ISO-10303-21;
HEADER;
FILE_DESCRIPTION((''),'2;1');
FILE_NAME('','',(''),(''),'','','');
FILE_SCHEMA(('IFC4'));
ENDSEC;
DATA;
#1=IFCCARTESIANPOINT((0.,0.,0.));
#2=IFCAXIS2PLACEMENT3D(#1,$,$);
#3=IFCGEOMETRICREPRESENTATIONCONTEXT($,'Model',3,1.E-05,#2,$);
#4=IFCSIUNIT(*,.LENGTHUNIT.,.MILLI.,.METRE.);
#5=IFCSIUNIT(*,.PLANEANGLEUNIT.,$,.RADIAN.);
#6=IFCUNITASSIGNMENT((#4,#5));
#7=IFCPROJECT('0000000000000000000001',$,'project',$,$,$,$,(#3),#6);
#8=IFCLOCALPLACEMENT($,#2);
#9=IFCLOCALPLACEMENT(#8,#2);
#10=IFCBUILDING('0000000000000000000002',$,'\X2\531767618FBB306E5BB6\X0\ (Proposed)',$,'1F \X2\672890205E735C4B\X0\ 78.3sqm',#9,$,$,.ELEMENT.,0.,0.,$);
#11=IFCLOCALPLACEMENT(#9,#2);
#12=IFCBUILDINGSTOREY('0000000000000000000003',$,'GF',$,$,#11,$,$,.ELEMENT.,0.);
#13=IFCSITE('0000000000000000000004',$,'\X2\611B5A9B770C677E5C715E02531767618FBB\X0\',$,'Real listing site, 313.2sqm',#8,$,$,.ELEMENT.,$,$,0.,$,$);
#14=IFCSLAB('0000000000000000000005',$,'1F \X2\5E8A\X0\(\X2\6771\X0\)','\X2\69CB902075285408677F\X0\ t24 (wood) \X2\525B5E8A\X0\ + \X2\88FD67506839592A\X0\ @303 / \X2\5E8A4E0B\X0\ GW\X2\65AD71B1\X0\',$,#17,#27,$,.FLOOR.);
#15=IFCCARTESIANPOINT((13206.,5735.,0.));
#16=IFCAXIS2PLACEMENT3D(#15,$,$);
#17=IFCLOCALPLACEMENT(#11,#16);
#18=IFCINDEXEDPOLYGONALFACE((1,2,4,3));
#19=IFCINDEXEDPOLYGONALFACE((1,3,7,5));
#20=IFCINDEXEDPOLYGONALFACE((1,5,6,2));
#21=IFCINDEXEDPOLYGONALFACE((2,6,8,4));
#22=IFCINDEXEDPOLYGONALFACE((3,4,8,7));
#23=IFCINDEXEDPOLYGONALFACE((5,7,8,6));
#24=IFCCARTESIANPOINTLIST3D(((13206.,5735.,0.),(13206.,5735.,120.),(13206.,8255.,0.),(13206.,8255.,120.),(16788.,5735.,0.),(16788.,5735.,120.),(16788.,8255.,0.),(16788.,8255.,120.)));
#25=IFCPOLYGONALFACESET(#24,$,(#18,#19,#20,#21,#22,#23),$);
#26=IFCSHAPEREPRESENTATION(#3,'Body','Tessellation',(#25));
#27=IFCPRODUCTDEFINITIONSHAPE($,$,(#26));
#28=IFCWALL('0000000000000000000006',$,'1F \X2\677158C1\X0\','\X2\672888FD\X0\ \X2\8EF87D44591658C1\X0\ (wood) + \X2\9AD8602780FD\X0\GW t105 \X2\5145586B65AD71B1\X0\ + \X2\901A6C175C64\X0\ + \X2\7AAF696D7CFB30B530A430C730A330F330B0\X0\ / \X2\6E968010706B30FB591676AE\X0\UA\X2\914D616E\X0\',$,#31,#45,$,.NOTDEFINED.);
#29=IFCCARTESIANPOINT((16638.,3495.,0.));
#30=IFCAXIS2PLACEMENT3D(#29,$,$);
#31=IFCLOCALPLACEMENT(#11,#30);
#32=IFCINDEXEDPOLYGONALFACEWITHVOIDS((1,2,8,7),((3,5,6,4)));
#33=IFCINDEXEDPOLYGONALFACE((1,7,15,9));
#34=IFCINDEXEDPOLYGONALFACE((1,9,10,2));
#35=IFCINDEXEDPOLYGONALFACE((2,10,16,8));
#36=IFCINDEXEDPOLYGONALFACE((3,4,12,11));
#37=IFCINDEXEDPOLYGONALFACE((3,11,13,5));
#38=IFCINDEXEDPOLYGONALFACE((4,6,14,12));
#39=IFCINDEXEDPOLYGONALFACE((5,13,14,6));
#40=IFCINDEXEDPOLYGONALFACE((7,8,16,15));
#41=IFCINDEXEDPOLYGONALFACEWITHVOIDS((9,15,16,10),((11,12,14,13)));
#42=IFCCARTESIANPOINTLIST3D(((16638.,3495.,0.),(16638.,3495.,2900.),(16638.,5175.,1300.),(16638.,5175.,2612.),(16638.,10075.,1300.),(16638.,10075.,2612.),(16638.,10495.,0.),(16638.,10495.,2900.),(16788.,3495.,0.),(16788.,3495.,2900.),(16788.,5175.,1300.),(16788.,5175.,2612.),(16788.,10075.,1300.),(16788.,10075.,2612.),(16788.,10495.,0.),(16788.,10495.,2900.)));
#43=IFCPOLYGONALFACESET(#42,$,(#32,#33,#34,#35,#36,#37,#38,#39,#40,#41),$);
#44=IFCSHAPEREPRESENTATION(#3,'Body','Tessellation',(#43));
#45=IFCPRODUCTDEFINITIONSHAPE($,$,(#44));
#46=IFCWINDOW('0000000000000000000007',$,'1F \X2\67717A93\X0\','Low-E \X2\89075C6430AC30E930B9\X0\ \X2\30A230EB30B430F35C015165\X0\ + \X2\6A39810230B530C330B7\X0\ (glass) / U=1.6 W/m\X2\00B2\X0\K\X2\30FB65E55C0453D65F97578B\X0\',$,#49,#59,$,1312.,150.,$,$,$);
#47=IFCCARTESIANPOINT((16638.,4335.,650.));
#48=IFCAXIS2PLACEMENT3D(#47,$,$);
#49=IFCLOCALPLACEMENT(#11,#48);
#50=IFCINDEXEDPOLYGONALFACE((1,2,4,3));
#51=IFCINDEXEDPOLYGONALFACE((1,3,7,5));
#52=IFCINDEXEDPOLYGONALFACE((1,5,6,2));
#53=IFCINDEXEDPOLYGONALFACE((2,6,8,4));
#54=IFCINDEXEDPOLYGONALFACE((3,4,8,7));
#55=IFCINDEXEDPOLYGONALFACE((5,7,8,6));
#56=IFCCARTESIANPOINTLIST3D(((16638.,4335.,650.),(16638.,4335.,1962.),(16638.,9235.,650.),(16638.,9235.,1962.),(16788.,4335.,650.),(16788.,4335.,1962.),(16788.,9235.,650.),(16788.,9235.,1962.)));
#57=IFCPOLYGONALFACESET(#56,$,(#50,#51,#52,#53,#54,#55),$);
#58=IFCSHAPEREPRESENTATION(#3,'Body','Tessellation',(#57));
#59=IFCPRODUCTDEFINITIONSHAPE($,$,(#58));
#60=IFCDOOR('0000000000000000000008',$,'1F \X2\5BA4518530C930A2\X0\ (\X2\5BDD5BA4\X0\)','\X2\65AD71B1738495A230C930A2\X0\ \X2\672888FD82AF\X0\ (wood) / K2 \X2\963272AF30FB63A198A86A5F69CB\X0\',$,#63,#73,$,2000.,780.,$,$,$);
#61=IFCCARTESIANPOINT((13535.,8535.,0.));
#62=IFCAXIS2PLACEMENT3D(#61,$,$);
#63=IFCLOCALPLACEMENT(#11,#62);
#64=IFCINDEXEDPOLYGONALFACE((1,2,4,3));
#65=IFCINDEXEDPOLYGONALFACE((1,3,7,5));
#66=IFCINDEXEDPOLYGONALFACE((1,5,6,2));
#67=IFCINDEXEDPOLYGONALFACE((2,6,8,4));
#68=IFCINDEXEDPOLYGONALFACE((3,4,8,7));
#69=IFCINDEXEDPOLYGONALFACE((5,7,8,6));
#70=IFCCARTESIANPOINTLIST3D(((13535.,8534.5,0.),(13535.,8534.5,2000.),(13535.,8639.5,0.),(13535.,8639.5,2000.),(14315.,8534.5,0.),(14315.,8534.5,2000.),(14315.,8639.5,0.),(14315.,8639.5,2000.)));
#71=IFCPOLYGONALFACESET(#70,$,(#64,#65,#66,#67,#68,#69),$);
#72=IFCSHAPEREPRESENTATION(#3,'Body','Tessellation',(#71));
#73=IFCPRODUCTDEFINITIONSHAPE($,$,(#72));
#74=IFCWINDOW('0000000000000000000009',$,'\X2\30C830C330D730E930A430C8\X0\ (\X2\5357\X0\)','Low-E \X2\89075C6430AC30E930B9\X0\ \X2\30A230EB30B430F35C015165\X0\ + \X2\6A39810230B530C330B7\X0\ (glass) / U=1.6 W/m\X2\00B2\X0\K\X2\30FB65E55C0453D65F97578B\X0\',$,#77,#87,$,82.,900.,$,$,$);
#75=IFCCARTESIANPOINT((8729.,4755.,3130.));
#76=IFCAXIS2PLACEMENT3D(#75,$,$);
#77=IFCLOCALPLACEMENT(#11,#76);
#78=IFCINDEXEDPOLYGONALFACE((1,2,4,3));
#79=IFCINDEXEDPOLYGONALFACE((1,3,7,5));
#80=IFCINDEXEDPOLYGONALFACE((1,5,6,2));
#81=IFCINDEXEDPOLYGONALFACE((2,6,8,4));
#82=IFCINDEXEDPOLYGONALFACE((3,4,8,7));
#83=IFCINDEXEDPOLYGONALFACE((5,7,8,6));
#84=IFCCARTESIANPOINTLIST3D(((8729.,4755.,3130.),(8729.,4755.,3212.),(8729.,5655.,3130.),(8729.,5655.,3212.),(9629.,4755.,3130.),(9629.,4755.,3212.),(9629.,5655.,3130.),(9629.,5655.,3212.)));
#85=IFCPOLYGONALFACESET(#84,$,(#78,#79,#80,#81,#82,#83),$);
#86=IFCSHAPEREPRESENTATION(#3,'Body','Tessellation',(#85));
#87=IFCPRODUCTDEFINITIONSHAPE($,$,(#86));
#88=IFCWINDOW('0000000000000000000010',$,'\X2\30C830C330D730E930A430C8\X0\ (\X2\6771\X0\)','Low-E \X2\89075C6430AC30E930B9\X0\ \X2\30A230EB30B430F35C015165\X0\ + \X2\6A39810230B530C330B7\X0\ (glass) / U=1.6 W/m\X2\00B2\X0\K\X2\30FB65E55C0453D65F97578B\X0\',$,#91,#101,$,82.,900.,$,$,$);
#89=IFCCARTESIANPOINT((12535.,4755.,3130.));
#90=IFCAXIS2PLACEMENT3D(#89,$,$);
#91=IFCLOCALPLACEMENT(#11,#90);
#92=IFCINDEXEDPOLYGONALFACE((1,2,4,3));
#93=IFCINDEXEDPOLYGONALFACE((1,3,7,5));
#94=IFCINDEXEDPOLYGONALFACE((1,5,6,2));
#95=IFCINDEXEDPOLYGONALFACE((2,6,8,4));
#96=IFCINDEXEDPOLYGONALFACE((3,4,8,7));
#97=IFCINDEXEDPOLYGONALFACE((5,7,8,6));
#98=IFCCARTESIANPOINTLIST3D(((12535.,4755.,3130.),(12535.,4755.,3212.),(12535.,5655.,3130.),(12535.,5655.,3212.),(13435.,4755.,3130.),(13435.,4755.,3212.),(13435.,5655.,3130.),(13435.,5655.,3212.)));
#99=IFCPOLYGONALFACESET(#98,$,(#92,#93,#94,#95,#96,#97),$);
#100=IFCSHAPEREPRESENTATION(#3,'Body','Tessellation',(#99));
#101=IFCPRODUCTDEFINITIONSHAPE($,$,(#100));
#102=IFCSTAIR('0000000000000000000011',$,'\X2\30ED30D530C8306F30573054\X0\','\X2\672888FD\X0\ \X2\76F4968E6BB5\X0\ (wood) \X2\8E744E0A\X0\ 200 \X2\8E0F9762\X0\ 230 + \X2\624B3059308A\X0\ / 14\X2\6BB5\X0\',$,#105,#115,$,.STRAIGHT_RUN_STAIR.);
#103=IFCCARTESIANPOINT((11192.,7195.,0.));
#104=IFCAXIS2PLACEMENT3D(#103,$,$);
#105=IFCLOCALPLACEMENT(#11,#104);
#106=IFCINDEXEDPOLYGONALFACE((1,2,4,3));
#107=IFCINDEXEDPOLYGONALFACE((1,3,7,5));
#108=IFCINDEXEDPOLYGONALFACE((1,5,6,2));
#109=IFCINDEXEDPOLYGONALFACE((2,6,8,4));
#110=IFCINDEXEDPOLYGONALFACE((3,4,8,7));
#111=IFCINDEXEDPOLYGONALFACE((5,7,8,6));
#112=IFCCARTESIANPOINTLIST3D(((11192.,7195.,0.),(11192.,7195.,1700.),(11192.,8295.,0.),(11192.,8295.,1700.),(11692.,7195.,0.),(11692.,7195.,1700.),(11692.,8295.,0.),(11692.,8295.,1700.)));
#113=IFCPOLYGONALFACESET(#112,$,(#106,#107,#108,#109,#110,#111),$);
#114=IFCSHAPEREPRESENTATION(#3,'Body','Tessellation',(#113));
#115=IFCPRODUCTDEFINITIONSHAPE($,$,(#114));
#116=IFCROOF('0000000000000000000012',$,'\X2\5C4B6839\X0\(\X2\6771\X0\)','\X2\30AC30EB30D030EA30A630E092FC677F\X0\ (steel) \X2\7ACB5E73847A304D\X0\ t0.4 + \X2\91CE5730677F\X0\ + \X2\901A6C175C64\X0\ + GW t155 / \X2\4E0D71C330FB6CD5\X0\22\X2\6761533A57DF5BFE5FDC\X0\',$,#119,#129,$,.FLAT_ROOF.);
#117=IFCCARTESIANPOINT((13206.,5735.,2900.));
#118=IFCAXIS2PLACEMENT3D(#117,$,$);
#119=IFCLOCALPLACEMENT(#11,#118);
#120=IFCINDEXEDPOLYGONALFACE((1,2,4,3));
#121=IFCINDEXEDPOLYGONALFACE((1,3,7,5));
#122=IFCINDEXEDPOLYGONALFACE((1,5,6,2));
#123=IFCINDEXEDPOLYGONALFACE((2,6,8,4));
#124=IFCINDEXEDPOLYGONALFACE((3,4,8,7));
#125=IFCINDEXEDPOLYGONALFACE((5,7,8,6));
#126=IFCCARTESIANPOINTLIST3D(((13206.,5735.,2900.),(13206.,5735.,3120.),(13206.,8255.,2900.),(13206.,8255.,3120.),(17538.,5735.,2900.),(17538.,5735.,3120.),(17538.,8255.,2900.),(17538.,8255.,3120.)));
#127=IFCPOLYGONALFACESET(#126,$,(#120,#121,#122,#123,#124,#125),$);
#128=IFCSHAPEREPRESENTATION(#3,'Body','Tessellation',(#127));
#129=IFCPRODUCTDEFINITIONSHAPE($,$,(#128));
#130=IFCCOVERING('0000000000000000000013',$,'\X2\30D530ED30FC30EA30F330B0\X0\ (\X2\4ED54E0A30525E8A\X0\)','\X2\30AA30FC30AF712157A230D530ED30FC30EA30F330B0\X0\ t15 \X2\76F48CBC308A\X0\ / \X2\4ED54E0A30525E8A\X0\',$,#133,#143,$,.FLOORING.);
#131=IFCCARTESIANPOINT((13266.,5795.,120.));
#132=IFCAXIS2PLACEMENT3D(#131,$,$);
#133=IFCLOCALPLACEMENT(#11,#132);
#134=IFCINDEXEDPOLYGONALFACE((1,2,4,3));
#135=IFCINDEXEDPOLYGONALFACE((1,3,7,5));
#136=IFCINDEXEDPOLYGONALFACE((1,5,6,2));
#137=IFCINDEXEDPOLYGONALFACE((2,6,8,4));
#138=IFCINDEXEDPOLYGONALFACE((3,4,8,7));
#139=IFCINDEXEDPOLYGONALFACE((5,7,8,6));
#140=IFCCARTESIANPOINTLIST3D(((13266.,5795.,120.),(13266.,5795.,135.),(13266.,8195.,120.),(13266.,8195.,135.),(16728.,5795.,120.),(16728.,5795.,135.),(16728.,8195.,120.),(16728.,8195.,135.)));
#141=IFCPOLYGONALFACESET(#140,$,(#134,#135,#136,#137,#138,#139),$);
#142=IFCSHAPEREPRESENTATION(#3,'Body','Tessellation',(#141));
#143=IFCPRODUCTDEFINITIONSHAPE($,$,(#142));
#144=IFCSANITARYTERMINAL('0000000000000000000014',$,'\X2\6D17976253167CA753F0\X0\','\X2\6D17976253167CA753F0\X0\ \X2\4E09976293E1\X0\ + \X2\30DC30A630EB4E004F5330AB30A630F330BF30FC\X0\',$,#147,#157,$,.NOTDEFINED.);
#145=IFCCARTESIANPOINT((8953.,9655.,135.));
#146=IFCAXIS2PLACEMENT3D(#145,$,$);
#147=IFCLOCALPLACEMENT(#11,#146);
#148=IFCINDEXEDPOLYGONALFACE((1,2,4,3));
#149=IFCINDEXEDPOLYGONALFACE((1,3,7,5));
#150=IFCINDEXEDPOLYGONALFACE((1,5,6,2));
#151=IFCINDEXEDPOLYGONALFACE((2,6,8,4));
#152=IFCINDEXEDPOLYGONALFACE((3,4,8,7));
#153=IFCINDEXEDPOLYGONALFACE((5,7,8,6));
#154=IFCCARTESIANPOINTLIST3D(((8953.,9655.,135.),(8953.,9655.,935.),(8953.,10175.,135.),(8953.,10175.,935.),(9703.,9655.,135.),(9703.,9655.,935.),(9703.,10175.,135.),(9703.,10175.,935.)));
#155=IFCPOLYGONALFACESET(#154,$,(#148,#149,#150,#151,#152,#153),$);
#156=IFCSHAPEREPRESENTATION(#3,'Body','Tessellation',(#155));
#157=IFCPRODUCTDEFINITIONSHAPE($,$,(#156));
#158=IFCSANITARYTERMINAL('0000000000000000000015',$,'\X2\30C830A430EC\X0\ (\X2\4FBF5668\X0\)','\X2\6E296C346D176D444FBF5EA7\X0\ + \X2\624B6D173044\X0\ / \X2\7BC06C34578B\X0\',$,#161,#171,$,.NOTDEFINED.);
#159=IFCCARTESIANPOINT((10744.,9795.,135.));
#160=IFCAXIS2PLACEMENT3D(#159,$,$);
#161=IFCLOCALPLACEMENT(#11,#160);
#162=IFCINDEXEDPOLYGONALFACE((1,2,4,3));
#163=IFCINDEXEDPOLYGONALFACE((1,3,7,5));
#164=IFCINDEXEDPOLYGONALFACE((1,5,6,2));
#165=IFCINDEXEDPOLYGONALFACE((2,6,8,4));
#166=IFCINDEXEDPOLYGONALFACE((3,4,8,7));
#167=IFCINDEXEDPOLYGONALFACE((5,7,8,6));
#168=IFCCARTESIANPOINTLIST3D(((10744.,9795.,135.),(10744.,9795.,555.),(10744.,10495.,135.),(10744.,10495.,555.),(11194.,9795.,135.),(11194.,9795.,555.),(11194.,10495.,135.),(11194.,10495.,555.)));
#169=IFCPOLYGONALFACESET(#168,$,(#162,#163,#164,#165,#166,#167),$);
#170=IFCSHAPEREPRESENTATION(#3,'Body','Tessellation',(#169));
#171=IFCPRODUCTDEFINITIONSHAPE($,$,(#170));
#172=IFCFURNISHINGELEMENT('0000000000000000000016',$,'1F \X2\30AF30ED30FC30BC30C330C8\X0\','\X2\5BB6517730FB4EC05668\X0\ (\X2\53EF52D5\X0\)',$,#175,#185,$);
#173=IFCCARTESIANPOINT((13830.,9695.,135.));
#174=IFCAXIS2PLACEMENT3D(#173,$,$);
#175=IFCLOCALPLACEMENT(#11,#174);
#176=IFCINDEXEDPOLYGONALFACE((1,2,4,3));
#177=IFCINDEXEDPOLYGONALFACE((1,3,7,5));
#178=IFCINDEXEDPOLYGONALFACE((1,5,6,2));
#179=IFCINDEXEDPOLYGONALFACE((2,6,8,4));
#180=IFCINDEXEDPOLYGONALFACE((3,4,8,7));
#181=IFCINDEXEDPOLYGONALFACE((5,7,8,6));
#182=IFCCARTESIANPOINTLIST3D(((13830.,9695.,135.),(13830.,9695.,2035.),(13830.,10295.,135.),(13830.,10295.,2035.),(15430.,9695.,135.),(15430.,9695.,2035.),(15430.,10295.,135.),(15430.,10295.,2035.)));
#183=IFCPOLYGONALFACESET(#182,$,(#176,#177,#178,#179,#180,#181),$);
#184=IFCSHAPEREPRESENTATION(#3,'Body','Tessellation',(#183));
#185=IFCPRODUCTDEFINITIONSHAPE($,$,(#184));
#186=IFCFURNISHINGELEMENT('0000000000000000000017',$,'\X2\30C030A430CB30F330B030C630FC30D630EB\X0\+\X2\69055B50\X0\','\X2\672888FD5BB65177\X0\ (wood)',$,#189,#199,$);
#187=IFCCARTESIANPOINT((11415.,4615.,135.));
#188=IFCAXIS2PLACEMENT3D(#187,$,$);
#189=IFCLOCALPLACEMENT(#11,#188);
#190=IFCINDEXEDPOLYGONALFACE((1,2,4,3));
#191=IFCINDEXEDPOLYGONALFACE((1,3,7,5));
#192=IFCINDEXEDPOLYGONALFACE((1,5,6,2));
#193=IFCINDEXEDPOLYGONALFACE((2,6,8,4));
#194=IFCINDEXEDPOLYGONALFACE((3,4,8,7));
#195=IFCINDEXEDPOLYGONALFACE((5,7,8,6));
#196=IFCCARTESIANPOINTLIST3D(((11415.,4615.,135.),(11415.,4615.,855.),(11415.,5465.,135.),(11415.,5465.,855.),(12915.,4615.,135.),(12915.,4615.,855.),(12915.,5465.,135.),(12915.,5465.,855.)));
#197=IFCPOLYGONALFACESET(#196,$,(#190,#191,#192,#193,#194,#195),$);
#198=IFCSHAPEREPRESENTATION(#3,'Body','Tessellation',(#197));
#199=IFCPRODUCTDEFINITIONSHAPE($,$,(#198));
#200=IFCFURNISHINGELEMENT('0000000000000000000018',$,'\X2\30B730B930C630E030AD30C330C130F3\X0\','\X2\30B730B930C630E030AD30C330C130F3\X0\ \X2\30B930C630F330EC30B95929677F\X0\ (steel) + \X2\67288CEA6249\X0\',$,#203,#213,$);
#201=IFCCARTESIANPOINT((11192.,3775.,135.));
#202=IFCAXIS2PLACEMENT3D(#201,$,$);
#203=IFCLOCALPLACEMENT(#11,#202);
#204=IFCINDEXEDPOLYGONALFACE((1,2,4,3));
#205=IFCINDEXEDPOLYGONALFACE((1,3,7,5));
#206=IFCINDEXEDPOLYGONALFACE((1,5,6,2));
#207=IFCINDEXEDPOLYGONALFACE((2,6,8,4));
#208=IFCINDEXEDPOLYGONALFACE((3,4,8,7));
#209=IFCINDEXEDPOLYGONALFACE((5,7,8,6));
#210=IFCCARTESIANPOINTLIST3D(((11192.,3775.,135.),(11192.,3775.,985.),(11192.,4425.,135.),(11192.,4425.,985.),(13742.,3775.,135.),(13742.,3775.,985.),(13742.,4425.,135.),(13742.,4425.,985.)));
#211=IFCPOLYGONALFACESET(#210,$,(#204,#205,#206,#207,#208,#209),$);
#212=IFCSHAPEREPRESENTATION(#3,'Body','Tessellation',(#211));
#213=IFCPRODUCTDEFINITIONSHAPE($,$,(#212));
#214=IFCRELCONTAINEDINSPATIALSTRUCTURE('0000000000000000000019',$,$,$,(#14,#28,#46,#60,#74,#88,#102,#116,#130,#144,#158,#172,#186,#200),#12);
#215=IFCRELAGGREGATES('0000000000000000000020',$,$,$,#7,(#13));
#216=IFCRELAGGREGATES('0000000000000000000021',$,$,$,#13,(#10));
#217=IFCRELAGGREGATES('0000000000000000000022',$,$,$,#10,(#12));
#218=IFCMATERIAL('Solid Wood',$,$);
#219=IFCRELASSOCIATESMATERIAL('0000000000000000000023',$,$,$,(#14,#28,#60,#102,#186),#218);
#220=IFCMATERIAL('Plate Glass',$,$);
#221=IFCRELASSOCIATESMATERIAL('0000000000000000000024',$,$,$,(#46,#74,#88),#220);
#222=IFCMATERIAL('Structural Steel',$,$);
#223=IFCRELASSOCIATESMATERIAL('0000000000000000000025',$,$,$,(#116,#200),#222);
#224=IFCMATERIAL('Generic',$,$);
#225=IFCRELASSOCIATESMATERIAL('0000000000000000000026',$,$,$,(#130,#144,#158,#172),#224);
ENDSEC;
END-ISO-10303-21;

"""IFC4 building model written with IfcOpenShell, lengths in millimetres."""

from ifc_helpers import new_model, si_unit, frame, frame_2d, origin, place, context, project, spatial, rectangle, extrude, material, element, fill, save


model = new_model("IFC4")

# Units and contexts
model_context = context("Model", 3, precision=1e-05, world=origin())
ifc_project = project(units=[si_unit("LENGTHUNIT", "METRE", prefix="MILLI"), si_unit("PLANEANGLEUNIT", "RADIAN")], contexts=[model_context])

# Site, building, storey
site_placement = place(None, origin())
site = spatial("IfcSite", under=ifc_project, at=site_placement, Name="愛媛県松山市北条辻", ObjectType="Real listing site, 313.2sqm", CompositionType="ELEMENT", RefElevation=0.0)
building_placement = place(site_placement, origin())
building = spatial("IfcBuilding", under=site, at=building_placement, Name="北条辻の家 (Proposed)", ObjectType="1F 木造平屋 78.3sqm", CompositionType="ELEMENT", ElevationOfRefHeight=0.0, ElevationOfTerrain=0.0)
storey_placement = place(building_placement, origin())
storey = spatial("IfcBuildingStorey", under=building, at=storey_placement, Name="GF", CompositionType="ELEMENT", Elevation=0.0)

# Slab
ifc_material_1 = material(Name="Solid Wood")
slab_1_placement = place(storey_placement, frame((13206.0, 5735.0, 0.0)))
element("IfcSlab", 1, at=slab_1_placement, inside=storey, material=ifc_material_1, Name="1F 床(東)", Description="構造用合板 t24 (wood) 剛床 + 製材根太 @303 / 床下 GW断熱", PredefinedType="FLOOR", context=model_context, shape_type="SweptSolid", body=[
    extrude(rectangle(XDim=3582.0, YDim=2520.0, at=frame_2d((1791.0, 1260.0))), frame((13206.0, 5735.0, 0.0)), (0.0, 0.0, 1.0), 120.0),
])

# Wall, opening, window
wall_1_placement = place(storey_placement, frame((16638.0, 3495.0, 0.0)))
wall_1 = element("IfcWall", 2, at=wall_1_placement, inside=storey, material=ifc_material_1, Name="1F 東壁", Description="木製 軸組外壁 (wood) + 高性能GW t105 充填断熱 + 通気層 + 窯業系サイディング / 準耐火・外皮UA配慮", PredefinedType="NOTDEFINED", context=model_context, shape_type="SweptSolid", body=[
    extrude(rectangle(XDim=150.0, YDim=7000.0, at=frame_2d((75.0, 3500.0))), frame((16638.0, 3495.0, 0.0)), (0.0, 0.0, 1.0), 2900.0),
])
opening_1_placement = place(storey_placement, frame((16638.0, 4335.0, 650.0)))
opening_1 = element("IfcOpeningElement", 3, at=opening_1_placement, cuts=wall_1, PredefinedType="NOTDEFINED", context=model_context, shape_type="SweptSolid", body=[
    extrude(rectangle(XDim=150.0, YDim=4900.0, at=frame_2d((75.0, 2450.0))), frame((16638.0, 4335.0, 650.0)), (0.0, 0.0, 1.0), 1312.0),
])
ifc_material_2 = material(Name="Plate Glass")
window_1_placement = place(storey_placement, frame((16638.0, 4335.0, 650.0)))
window_1 = element("IfcWindow", 4, at=window_1_placement, inside=storey, material=ifc_material_2, Name="1F 東窓", Description="Low-E 複層ガラス アルゴン封入 + 樹脂サッシ (glass) / U=1.6 W/m²K・日射取得型", OverallHeight=1312.0, OverallWidth=150.0, context=model_context, shape_type="SweptSolid", body=[
    extrude(rectangle(XDim=150.0, YDim=4900.0, at=frame_2d((75.0, 2450.0))), frame((16638.0, 4335.0, 650.0)), (0.0, 0.0, 1.0), 1312.0),
])
fill(opening_1, window_1)

# Door
door_placement = place(storey_placement, frame((13535.0, 8535.0, 0.0)))
element("IfcDoor", 5, at=door_placement, inside=storey, material=ifc_material_1, Name="1F 室内ドア (寝室)", Description="断熱玄関ドア 木製芯 (wood) / K2 防犯・採風機構", OverallHeight=2000.0, OverallWidth=780.0, context=model_context, shape_type="SweptSolid", body=[
    extrude(rectangle(XDim=780.0, YDim=105.0, at=frame_2d((390.0, 52.0))), frame((13535.0, 8535.0, 0.0)), (0.0, 0.0, 1.0), 2000.0),
])

# Windows
window_2_placement = place(storey_placement, frame((8729.0, 4755.0, 3130.0)))
element("IfcWindow", 6, at=window_2_placement, inside=storey, material=ifc_material_2, Name="トップライト (南)", Description="Low-E 複層ガラス アルゴン封入 + 樹脂サッシ (glass) / U=1.6 W/m²K・日射取得型", OverallHeight=82.0, OverallWidth=900.0, context=model_context, shape_type="SweptSolid", body=[
    extrude(rectangle(XDim=900.0, YDim=900.0, at=frame_2d((450.0, 450.0))), frame((8729.0, 4755.0, 3130.0)), (0.0, 0.0, 1.0), 82.0),
])
window_3_placement = place(storey_placement, frame((12535.0, 4755.0, 3130.0)))
element("IfcWindow", 7, at=window_3_placement, inside=storey, material=ifc_material_2, Name="トップライト (東)", Description="Low-E 複層ガラス アルゴン封入 + 樹脂サッシ (glass) / U=1.6 W/m²K・日射取得型", OverallHeight=82.0, OverallWidth=900.0, context=model_context, shape_type="SweptSolid", body=[
    extrude(rectangle(XDim=900.0, YDim=900.0, at=frame_2d((450.0, 450.0))), frame((12535.0, 4755.0, 3130.0)), (0.0, 0.0, 1.0), 82.0),
])

# Stair
stair_placement = place(storey_placement, frame((11192.0, 7195.0, 0.0)))
element("IfcStair", 8, at=stair_placement, inside=storey, material=ifc_material_1, Name="ロフトはしご", Description="木製 直階段 (wood) 蹴上 200 踏面 230 + 手すり / 14段", PredefinedType="STRAIGHT_RUN_STAIR", context=model_context, shape_type="SweptSolid", body=[
    extrude(rectangle(XDim=500.0, YDim=1100.0, at=frame_2d((250.0, 550.0))), frame((11192.0, 7195.0, 0.0)), (0.0, 0.0, 1.0), 1700.0),
])

# Roof
ifc_material_3 = material(Name="Structural Steel")
roof_placement = place(storey_placement, frame((13206.0, 5735.0, 2900.0)))
element("IfcRoof", 9, at=roof_placement, inside=storey, material=ifc_material_3, Name="屋根(東)", Description="ガルバリウム鋼板 (steel) 立平葺き t0.4 + 野地板 + 通気層 + GW t155 / 不燃・法22条区域対応", PredefinedType="FLAT_ROOF", context=model_context, shape_type="SweptSolid", body=[
    extrude(rectangle(XDim=4332.0, YDim=2520.0, at=frame_2d((2166.0, 1260.0))), frame((13206.0, 5735.0, 2900.0)), (0.0, 0.0, 1.0), 220.0),
])

# Covering
ifc_material_4 = material(Name="Generic")
covering_placement = place(storey_placement, frame((13266.0, 5795.0, 120.0)))
element("IfcCovering", 10, at=covering_placement, inside=storey, material=ifc_material_4, Name="フローリング (仕上げ床)", Description="オーク無垢フローリング t15 直貼り / 仕上げ床", PredefinedType="FLOORING", context=model_context, shape_type="SweptSolid", body=[
    extrude(rectangle(XDim=3462.0, YDim=2400.0, at=frame_2d((1731.0, 1200.0))), frame((13266.0, 5795.0, 120.0)), (0.0, 0.0, 1.0), 15.0),
])

# Sanitary terminals
sanitary_terminal_1_placement = place(storey_placement, frame((8953.0, 9655.0, 135.0)))
element("IfcSanitaryTerminal", 11, at=sanitary_terminal_1_placement, inside=storey, material=ifc_material_4, Name="洗面化粧台", Description="洗面化粧台 三面鏡 + ボウル一体カウンター", PredefinedType="NOTDEFINED", context=model_context, shape_type="SweptSolid", body=[
    extrude(rectangle(XDim=750.0, YDim=520.0, at=frame_2d((375.0, 260.0))), frame((8953.0, 9655.0, 135.0)), (0.0, 0.0, 1.0), 800.0),
])
sanitary_terminal_2_placement = place(storey_placement, frame((10744.0, 9795.0, 135.0)))
element("IfcSanitaryTerminal", 12, at=sanitary_terminal_2_placement, inside=storey, material=ifc_material_4, Name="トイレ (便器)", Description="温水洗浄便座 + 手洗い / 節水型", PredefinedType="NOTDEFINED", context=model_context, shape_type="SweptSolid", body=[
    extrude(rectangle(XDim=450.0, YDim=700.0, at=frame_2d((225.0, 350.0))), frame((10744.0, 9795.0, 135.0)), (0.0, 0.0, 1.0), 420.0),
])

# Furnishing elements
furnishing_1_placement = place(storey_placement, frame((13830.0, 9695.0, 135.0)))
element("IfcFurnishingElement", 13, at=furnishing_1_placement, inside=storey, material=ifc_material_4, Name="1F クローゼット", Description="家具・什器 (可動)", context=model_context, shape_type="SweptSolid", body=[
    extrude(rectangle(XDim=1600.0, YDim=600.0, at=frame_2d((800.0, 300.0))), frame((13830.0, 9695.0, 135.0)), (0.0, 0.0, 1.0), 1900.0),
])
furnishing_2_placement = place(storey_placement, frame((11415.0, 4615.0, 135.0)))
element("IfcFurnishingElement", 14, at=furnishing_2_placement, inside=storey, material=ifc_material_1, Name="ダイニングテーブル+椅子", Description="木製家具 (wood)", context=model_context, shape_type="SweptSolid", body=[
    extrude(rectangle(XDim=1500.0, YDim=850.0, at=frame_2d((750.0, 425.0))), frame((11415.0, 4615.0, 135.0)), (0.0, 0.0, 1.0), 720.0),
])
furnishing_3_placement = place(storey_placement, frame((11192.0, 3775.0, 135.0)))
element("IfcFurnishingElement", 15, at=furnishing_3_placement, inside=storey, material=ifc_material_3, Name="システムキッチン", Description="システムキッチン ステンレス天板 (steel) + 木質扉", context=model_context, shape_type="SweptSolid", body=[
    extrude(rectangle(XDim=2550.0, YDim=650.0, at=frame_2d((1275.0, 325.0))), frame((11192.0, 3775.0, 135.0)), (0.0, 0.0, 1.0), 850.0),
])

save(model, "model.ifc")
